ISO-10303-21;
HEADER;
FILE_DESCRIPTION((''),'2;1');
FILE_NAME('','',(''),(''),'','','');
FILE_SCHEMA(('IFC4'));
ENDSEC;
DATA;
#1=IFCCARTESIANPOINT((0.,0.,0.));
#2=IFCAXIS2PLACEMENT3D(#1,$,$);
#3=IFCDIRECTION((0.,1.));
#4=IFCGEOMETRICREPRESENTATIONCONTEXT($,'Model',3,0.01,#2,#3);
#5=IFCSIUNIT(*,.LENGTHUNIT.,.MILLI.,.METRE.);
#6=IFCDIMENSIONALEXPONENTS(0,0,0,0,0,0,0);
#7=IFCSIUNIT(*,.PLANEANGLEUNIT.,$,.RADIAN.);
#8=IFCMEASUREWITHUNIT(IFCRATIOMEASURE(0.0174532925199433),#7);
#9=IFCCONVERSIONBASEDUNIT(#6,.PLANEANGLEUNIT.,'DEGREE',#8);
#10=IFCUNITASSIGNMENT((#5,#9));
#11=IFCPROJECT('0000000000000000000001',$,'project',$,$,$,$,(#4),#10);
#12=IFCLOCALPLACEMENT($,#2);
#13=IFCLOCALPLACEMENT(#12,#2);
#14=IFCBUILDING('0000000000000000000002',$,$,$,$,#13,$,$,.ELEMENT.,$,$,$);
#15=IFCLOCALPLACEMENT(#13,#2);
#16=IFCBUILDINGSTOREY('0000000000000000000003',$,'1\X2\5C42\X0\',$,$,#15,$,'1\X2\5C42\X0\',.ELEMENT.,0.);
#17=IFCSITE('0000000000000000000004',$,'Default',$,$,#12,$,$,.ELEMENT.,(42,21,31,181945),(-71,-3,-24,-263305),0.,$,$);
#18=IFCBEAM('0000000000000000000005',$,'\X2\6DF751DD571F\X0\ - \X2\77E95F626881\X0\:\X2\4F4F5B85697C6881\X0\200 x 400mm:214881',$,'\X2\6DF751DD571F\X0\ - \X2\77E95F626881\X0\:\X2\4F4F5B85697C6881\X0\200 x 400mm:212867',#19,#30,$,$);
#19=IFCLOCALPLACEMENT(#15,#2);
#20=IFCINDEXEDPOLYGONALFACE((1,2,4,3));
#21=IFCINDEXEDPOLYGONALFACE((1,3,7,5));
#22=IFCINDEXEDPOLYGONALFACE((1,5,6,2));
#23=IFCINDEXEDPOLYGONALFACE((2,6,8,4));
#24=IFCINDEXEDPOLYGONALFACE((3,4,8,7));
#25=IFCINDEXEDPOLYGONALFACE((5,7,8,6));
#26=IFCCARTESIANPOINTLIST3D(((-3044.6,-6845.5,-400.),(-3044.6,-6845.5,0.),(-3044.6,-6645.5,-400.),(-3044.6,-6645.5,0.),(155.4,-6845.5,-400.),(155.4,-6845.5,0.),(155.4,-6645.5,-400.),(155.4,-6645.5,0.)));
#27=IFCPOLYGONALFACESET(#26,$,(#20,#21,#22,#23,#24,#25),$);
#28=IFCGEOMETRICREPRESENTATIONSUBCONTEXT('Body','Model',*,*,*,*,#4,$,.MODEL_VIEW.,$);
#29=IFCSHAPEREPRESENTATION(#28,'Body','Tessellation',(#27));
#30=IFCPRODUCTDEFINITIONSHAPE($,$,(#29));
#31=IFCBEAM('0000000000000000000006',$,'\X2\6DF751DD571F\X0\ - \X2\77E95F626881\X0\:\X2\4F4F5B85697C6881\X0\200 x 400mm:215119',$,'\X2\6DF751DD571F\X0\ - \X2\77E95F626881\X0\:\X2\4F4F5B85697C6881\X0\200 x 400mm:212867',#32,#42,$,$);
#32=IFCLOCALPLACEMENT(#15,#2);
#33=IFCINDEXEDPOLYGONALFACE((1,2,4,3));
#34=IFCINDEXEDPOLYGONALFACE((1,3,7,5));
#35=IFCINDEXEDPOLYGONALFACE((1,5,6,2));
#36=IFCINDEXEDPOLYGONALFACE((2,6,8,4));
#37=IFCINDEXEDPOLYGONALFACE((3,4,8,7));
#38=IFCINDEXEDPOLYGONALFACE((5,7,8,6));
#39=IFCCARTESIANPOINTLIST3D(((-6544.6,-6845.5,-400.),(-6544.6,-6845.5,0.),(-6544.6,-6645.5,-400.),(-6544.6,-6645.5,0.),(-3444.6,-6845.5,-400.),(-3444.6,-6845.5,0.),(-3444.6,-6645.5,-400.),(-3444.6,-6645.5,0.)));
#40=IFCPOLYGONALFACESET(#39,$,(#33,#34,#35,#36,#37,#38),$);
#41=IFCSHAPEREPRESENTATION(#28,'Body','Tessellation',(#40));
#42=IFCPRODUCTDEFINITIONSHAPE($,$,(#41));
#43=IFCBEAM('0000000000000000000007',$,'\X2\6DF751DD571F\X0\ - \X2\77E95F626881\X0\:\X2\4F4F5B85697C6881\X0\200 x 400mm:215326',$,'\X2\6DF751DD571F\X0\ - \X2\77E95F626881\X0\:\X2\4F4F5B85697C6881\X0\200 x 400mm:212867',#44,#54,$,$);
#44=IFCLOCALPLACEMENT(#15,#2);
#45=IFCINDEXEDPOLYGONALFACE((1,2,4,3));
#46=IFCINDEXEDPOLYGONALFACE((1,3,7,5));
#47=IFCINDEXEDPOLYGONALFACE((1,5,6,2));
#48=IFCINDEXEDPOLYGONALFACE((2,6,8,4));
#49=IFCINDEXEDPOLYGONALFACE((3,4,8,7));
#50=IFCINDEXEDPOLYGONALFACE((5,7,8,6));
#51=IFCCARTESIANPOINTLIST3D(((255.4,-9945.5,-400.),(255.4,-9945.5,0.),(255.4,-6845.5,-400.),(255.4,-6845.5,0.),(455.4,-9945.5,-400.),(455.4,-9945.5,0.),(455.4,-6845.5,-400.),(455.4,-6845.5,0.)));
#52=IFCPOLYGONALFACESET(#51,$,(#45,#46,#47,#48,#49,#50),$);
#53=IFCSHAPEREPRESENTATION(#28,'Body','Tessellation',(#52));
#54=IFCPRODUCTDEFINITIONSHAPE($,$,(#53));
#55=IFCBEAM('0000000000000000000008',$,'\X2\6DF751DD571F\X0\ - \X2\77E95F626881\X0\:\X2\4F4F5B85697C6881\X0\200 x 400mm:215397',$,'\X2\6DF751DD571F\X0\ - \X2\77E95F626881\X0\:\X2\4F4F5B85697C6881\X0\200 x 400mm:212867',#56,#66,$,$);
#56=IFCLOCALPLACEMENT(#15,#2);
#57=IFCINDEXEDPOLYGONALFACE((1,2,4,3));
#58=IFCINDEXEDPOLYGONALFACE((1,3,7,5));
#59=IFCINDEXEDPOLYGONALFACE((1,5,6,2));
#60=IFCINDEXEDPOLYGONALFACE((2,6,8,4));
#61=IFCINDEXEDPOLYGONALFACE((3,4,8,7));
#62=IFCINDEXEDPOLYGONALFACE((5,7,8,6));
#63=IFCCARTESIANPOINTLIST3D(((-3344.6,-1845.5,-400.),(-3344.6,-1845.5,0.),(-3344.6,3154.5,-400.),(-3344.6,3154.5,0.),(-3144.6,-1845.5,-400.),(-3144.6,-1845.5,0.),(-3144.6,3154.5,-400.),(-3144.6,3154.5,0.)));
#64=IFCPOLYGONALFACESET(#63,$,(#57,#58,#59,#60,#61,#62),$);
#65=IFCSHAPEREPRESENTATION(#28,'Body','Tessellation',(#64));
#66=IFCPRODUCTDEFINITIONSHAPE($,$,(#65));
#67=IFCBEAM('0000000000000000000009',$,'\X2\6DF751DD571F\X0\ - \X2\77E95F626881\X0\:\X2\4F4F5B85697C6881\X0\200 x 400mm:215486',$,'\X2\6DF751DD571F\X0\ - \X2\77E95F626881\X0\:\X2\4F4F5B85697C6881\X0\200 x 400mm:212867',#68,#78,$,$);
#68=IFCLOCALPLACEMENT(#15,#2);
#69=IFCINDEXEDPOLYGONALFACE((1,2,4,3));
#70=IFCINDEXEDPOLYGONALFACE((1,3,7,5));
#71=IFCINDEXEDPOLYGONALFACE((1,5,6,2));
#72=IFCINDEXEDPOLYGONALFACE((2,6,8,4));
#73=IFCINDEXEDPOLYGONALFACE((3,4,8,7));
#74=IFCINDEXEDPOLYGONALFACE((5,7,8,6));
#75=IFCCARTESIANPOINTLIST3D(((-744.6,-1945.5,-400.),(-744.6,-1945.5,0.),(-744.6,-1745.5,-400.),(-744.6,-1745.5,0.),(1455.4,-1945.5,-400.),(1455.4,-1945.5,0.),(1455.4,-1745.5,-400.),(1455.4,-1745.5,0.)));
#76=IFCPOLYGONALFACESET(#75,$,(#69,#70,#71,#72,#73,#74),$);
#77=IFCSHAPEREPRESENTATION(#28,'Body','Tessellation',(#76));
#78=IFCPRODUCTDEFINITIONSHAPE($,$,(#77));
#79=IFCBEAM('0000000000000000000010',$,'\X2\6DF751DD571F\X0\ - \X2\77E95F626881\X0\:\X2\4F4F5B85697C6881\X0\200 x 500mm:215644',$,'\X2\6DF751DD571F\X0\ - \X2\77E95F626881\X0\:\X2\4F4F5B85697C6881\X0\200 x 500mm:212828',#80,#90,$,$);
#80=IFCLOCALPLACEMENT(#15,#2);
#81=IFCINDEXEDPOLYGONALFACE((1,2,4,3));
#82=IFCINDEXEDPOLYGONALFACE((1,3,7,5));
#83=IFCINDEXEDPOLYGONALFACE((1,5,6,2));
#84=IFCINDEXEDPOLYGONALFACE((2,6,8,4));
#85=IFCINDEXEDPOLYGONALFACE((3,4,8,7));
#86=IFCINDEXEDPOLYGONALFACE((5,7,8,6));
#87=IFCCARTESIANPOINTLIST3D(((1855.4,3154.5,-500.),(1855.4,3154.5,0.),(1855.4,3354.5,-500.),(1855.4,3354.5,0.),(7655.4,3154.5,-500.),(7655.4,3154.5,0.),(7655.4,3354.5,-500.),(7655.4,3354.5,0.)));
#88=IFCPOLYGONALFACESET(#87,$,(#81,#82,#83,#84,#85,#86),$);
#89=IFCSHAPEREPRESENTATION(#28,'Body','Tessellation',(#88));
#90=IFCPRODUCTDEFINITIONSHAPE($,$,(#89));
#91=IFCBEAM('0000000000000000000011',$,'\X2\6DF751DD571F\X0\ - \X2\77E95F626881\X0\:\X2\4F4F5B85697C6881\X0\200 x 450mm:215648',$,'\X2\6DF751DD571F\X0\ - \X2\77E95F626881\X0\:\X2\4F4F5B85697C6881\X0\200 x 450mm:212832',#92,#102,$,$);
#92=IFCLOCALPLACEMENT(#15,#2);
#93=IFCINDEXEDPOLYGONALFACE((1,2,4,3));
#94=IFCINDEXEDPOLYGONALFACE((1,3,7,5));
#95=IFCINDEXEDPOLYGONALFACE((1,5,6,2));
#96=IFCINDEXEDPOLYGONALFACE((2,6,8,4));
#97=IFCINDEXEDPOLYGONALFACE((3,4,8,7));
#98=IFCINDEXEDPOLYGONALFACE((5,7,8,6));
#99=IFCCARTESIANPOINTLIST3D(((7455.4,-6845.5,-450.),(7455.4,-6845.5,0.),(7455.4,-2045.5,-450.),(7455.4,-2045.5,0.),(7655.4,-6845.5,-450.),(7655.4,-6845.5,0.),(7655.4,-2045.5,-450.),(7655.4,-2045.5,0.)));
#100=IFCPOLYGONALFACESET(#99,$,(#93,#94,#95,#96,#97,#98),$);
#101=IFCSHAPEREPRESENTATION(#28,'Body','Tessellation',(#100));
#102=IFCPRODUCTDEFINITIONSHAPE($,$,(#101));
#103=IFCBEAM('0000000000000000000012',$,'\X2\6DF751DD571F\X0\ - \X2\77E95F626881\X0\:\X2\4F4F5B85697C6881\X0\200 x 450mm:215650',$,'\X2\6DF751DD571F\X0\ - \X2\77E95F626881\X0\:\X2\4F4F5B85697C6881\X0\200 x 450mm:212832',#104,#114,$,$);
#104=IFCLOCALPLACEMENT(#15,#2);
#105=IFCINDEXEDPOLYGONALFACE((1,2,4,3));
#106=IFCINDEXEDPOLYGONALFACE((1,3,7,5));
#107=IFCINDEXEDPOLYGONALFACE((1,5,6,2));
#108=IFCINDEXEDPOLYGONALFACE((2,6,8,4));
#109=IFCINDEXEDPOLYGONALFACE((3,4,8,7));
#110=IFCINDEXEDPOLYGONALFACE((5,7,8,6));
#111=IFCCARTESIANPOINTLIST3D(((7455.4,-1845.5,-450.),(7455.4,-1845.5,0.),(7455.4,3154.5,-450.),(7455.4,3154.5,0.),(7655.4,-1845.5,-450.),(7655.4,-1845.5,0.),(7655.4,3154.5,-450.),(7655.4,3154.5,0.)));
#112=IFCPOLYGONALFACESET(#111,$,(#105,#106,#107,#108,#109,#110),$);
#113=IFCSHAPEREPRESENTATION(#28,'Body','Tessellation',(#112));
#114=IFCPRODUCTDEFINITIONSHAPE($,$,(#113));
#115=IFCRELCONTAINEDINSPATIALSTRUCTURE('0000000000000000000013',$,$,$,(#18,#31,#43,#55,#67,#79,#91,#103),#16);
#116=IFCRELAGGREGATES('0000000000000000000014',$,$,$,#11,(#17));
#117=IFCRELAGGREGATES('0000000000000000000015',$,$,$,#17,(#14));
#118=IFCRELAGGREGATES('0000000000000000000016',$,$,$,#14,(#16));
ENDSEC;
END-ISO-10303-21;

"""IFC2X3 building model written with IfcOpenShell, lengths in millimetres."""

from ifc_helpers import new_model, entity, si_unit, converted_unit, direction, frame, frame_2d, origin, place, context, subcontext, project, spatial, rectangle, extrude, element, save


model = new_model("IFC2X3")

# Units and contexts
model_context = context("Model", 3, precision=0.01, world=origin(), true_north=direction((0.0, 1.0)))
body_context = subcontext(model_context, "Body", "Model", "MODEL_VIEW")
ifc_project = project(units=[si_unit("LENGTHUNIT", "METRE", prefix="MILLI"), converted_unit("PLANEANGLEUNIT", "DEGREE", entity("IfcRatioMeasure", 0.0174532925199433), si_unit("PLANEANGLEUNIT", "RADIAN"), dimensions=[0, 0, 0, 0, 0, 0, 0])], contexts=[model_context])

# Site, building, storey
site_placement = place(None, origin())
site = spatial("IfcSite", under=ifc_project, at=site_placement, Name="Default", CompositionType="ELEMENT", RefLatitude=(42, 21, 31, 181945), RefLongitude=(-71, -3, -24, -263305), RefElevation=0.0)
building_placement = place(site_placement, origin())
building = spatial("IfcBuilding", under=site, at=building_placement, CompositionType="ELEMENT")
storey_placement = place(building_placement, origin())
storey = spatial("IfcBuildingStorey", under=building, at=storey_placement, Name="1层", LongName="1层", CompositionType="ELEMENT", Elevation=0.0)

# Beams
beam_1_placement = place(storey_placement, frame((-3244.6, -6745.5, 0.0)))
element("IfcBeam", 1, at=beam_1_placement, inside=storey, Name="混凝土 - 矩形梁:住宅楼梁200 x 400mm:214881", ObjectType="混凝土 - 矩形梁:住宅楼梁200 x 400mm:212867", context=body_context, shape_type="SweptSolid", body=[
    extrude(rectangle(XDim=400.0, YDim=200.0, at=frame_2d((0.0, 0.0), x_axis=(1.0, 0.0))), frame((200.0, 0.0, -200.0), z_axis=(1.0, 0.0, 0.0), x_axis=(0.0, 0.0, -1.0)), (0.0, 0.0, 1.0), 3200.0),
])
beam_2_placement = place(storey_placement, frame((-3244.6, -6745.5, 0.0), z_axis=(0.0, 0.0, 1.0), x_axis=(-1.0, 0.0, 0.0)))
element("IfcBeam", 2, at=beam_2_placement, inside=storey, Name="混凝土 - 矩形梁:住宅楼梁200 x 400mm:215119", ObjectType="混凝土 - 矩形梁:住宅楼梁200 x 400mm:212867", context=body_context, shape_type="SweptSolid", body=[
    extrude(rectangle(XDim=400.0, YDim=200.0, at=frame_2d((0.0, 0.0), x_axis=(1.0, 0.0))), frame((200.0, 0.0, -200.0), z_axis=(1.0, 0.0, 0.0), x_axis=(0.0, 0.0, -1.0)), (0.0, 0.0, 1.0), 3100.0),
])
beam_3_placement = place(storey_placement, frame((355.4, -10145.5, 0.0), z_axis=(0.0, 0.0, 1.0), x_axis=(0.0, 1.0, 0.0)))
element("IfcBeam", 3, at=beam_3_placement, inside=storey, Name="混凝土 - 矩形梁:住宅楼梁200 x 400mm:215326", ObjectType="混凝土 - 矩形梁:住宅楼梁200 x 400mm:212867", context=body_context, shape_type="SweptSolid", body=[
    extrude(rectangle(XDim=400.0, YDim=200.0, at=frame_2d((0.0, 0.0), x_axis=(1.0, 0.0))), frame((200.0, 0.0, -200.0), z_axis=(1.0, 0.0, 0.0), x_axis=(0.0, 0.0, -1.0)), (0.0, 0.0, 1.0), 3100.0),
])
beam_4_placement = place(storey_placement, frame((-3244.6, 3254.5, 0.0), z_axis=(0.0, 0.0, 1.0), x_axis=(0.0, -1.0, 0.0)))
element("IfcBeam", 4, at=beam_4_placement, inside=storey, Name="混凝土 - 矩形梁:住宅楼梁200 x 400mm:215397", ObjectType="混凝土 - 矩形梁:住宅楼梁200 x 400mm:212867", context=body_context, shape_type="SweptSolid", body=[
    extrude(rectangle(XDim=400.0, YDim=200.0, at=frame_2d((0.0, 0.0), x_axis=(1.0, 0.0))), frame((100.0, 0.0, -200.0), z_axis=(1.0, 0.0, 0.0), x_axis=(0.0, 0.0, -1.0)), (0.0, 0.0, 1.0), 5000.0),
])
beam_5_placement = place(storey_placement, frame((-944.6, -1845.5, 0.0)))
element("IfcBeam", 5, at=beam_5_placement, inside=storey, Name="混凝土 - 矩形梁:住宅楼梁200 x 400mm:215486", ObjectType="混凝土 - 矩形梁:住宅楼梁200 x 400mm:212867", context=body_context, shape_type="SweptSolid", body=[
    extrude(rectangle(XDim=400.0, YDim=200.0, at=frame_2d((0.0, 0.0), x_axis=(1.0, 0.0))), frame((200.0, 0.0, -200.0), z_axis=(1.0, 0.0, 0.0), x_axis=(0.0, 0.0, -1.0)), (0.0, 0.0, 1.0), 2200.0),
])
beam_6_placement = place(storey_placement, frame((7555.4, 3254.5, 0.0), z_axis=(0.0, 0.0, 1.0), x_axis=(-1.0, 0.0, 0.0)))
element("IfcBeam", 6, at=beam_6_placement, inside=storey, Name="混凝土 - 矩形梁:住宅楼梁200 x 500mm:215644", ObjectType="混凝土 - 矩形梁:住宅楼梁200 x 500mm:212828", context=body_context, shape_type="SweptSolid", body=[
    extrude(rectangle(XDim=500.0, YDim=200.0, at=frame_2d((0.0, 0.0), x_axis=(1.0, 0.0))), frame((-100.0, 0.0, -250.0), z_axis=(1.0, 0.0, 0.0), x_axis=(0.0, 0.0, -1.0)), (0.0, 0.0, 1.0), 5800.0),
])
beam_7_placement = place(storey_placement, frame((7555.4, -1945.5, 0.0), z_axis=(0.0, 0.0, 1.0), x_axis=(0.0, -1.0, 0.0)))
element("IfcBeam", 7, at=beam_7_placement, inside=storey, Name="混凝土 - 矩形梁:住宅楼梁200 x 450mm:215648", ObjectType="混凝土 - 矩形梁:住宅楼梁200 x 450mm:212832", context=body_context, shape_type="SweptSolid", body=[
    extrude(rectangle(XDim=450.0, YDim=200.0, at=frame_2d((0.0, 0.0), x_axis=(1.0, 0.0))), frame((100.0, 0.0, -225.0), z_axis=(1.0, 0.0, 0.0), x_axis=(0.0, 0.0, -1.0)), (0.0, 0.0, 1.0), 4800.0),
])
beam_8_placement = place(storey_placement, frame((7555.4, 3254.5, 0.0), z_axis=(0.0, 0.0, 1.0), x_axis=(0.0, -1.0, 0.0)))
element("IfcBeam", 8, at=beam_8_placement, inside=storey, Name="混凝土 - 矩形梁:住宅楼梁200 x 450mm:215650", ObjectType="混凝土 - 矩形梁:住宅楼梁200 x 450mm:212832", context=body_context, shape_type="SweptSolid", body=[
    extrude(rectangle(XDim=450.0, YDim=200.0, at=frame_2d((0.0, 0.0), x_axis=(1.0, 0.0))), frame((100.0, 0.0, -225.0), z_axis=(1.0, 0.0, 0.0), x_axis=(0.0, 0.0, -1.0)), (0.0, 0.0, 1.0), 5000.0),
])

save(model, "model.ifc")
